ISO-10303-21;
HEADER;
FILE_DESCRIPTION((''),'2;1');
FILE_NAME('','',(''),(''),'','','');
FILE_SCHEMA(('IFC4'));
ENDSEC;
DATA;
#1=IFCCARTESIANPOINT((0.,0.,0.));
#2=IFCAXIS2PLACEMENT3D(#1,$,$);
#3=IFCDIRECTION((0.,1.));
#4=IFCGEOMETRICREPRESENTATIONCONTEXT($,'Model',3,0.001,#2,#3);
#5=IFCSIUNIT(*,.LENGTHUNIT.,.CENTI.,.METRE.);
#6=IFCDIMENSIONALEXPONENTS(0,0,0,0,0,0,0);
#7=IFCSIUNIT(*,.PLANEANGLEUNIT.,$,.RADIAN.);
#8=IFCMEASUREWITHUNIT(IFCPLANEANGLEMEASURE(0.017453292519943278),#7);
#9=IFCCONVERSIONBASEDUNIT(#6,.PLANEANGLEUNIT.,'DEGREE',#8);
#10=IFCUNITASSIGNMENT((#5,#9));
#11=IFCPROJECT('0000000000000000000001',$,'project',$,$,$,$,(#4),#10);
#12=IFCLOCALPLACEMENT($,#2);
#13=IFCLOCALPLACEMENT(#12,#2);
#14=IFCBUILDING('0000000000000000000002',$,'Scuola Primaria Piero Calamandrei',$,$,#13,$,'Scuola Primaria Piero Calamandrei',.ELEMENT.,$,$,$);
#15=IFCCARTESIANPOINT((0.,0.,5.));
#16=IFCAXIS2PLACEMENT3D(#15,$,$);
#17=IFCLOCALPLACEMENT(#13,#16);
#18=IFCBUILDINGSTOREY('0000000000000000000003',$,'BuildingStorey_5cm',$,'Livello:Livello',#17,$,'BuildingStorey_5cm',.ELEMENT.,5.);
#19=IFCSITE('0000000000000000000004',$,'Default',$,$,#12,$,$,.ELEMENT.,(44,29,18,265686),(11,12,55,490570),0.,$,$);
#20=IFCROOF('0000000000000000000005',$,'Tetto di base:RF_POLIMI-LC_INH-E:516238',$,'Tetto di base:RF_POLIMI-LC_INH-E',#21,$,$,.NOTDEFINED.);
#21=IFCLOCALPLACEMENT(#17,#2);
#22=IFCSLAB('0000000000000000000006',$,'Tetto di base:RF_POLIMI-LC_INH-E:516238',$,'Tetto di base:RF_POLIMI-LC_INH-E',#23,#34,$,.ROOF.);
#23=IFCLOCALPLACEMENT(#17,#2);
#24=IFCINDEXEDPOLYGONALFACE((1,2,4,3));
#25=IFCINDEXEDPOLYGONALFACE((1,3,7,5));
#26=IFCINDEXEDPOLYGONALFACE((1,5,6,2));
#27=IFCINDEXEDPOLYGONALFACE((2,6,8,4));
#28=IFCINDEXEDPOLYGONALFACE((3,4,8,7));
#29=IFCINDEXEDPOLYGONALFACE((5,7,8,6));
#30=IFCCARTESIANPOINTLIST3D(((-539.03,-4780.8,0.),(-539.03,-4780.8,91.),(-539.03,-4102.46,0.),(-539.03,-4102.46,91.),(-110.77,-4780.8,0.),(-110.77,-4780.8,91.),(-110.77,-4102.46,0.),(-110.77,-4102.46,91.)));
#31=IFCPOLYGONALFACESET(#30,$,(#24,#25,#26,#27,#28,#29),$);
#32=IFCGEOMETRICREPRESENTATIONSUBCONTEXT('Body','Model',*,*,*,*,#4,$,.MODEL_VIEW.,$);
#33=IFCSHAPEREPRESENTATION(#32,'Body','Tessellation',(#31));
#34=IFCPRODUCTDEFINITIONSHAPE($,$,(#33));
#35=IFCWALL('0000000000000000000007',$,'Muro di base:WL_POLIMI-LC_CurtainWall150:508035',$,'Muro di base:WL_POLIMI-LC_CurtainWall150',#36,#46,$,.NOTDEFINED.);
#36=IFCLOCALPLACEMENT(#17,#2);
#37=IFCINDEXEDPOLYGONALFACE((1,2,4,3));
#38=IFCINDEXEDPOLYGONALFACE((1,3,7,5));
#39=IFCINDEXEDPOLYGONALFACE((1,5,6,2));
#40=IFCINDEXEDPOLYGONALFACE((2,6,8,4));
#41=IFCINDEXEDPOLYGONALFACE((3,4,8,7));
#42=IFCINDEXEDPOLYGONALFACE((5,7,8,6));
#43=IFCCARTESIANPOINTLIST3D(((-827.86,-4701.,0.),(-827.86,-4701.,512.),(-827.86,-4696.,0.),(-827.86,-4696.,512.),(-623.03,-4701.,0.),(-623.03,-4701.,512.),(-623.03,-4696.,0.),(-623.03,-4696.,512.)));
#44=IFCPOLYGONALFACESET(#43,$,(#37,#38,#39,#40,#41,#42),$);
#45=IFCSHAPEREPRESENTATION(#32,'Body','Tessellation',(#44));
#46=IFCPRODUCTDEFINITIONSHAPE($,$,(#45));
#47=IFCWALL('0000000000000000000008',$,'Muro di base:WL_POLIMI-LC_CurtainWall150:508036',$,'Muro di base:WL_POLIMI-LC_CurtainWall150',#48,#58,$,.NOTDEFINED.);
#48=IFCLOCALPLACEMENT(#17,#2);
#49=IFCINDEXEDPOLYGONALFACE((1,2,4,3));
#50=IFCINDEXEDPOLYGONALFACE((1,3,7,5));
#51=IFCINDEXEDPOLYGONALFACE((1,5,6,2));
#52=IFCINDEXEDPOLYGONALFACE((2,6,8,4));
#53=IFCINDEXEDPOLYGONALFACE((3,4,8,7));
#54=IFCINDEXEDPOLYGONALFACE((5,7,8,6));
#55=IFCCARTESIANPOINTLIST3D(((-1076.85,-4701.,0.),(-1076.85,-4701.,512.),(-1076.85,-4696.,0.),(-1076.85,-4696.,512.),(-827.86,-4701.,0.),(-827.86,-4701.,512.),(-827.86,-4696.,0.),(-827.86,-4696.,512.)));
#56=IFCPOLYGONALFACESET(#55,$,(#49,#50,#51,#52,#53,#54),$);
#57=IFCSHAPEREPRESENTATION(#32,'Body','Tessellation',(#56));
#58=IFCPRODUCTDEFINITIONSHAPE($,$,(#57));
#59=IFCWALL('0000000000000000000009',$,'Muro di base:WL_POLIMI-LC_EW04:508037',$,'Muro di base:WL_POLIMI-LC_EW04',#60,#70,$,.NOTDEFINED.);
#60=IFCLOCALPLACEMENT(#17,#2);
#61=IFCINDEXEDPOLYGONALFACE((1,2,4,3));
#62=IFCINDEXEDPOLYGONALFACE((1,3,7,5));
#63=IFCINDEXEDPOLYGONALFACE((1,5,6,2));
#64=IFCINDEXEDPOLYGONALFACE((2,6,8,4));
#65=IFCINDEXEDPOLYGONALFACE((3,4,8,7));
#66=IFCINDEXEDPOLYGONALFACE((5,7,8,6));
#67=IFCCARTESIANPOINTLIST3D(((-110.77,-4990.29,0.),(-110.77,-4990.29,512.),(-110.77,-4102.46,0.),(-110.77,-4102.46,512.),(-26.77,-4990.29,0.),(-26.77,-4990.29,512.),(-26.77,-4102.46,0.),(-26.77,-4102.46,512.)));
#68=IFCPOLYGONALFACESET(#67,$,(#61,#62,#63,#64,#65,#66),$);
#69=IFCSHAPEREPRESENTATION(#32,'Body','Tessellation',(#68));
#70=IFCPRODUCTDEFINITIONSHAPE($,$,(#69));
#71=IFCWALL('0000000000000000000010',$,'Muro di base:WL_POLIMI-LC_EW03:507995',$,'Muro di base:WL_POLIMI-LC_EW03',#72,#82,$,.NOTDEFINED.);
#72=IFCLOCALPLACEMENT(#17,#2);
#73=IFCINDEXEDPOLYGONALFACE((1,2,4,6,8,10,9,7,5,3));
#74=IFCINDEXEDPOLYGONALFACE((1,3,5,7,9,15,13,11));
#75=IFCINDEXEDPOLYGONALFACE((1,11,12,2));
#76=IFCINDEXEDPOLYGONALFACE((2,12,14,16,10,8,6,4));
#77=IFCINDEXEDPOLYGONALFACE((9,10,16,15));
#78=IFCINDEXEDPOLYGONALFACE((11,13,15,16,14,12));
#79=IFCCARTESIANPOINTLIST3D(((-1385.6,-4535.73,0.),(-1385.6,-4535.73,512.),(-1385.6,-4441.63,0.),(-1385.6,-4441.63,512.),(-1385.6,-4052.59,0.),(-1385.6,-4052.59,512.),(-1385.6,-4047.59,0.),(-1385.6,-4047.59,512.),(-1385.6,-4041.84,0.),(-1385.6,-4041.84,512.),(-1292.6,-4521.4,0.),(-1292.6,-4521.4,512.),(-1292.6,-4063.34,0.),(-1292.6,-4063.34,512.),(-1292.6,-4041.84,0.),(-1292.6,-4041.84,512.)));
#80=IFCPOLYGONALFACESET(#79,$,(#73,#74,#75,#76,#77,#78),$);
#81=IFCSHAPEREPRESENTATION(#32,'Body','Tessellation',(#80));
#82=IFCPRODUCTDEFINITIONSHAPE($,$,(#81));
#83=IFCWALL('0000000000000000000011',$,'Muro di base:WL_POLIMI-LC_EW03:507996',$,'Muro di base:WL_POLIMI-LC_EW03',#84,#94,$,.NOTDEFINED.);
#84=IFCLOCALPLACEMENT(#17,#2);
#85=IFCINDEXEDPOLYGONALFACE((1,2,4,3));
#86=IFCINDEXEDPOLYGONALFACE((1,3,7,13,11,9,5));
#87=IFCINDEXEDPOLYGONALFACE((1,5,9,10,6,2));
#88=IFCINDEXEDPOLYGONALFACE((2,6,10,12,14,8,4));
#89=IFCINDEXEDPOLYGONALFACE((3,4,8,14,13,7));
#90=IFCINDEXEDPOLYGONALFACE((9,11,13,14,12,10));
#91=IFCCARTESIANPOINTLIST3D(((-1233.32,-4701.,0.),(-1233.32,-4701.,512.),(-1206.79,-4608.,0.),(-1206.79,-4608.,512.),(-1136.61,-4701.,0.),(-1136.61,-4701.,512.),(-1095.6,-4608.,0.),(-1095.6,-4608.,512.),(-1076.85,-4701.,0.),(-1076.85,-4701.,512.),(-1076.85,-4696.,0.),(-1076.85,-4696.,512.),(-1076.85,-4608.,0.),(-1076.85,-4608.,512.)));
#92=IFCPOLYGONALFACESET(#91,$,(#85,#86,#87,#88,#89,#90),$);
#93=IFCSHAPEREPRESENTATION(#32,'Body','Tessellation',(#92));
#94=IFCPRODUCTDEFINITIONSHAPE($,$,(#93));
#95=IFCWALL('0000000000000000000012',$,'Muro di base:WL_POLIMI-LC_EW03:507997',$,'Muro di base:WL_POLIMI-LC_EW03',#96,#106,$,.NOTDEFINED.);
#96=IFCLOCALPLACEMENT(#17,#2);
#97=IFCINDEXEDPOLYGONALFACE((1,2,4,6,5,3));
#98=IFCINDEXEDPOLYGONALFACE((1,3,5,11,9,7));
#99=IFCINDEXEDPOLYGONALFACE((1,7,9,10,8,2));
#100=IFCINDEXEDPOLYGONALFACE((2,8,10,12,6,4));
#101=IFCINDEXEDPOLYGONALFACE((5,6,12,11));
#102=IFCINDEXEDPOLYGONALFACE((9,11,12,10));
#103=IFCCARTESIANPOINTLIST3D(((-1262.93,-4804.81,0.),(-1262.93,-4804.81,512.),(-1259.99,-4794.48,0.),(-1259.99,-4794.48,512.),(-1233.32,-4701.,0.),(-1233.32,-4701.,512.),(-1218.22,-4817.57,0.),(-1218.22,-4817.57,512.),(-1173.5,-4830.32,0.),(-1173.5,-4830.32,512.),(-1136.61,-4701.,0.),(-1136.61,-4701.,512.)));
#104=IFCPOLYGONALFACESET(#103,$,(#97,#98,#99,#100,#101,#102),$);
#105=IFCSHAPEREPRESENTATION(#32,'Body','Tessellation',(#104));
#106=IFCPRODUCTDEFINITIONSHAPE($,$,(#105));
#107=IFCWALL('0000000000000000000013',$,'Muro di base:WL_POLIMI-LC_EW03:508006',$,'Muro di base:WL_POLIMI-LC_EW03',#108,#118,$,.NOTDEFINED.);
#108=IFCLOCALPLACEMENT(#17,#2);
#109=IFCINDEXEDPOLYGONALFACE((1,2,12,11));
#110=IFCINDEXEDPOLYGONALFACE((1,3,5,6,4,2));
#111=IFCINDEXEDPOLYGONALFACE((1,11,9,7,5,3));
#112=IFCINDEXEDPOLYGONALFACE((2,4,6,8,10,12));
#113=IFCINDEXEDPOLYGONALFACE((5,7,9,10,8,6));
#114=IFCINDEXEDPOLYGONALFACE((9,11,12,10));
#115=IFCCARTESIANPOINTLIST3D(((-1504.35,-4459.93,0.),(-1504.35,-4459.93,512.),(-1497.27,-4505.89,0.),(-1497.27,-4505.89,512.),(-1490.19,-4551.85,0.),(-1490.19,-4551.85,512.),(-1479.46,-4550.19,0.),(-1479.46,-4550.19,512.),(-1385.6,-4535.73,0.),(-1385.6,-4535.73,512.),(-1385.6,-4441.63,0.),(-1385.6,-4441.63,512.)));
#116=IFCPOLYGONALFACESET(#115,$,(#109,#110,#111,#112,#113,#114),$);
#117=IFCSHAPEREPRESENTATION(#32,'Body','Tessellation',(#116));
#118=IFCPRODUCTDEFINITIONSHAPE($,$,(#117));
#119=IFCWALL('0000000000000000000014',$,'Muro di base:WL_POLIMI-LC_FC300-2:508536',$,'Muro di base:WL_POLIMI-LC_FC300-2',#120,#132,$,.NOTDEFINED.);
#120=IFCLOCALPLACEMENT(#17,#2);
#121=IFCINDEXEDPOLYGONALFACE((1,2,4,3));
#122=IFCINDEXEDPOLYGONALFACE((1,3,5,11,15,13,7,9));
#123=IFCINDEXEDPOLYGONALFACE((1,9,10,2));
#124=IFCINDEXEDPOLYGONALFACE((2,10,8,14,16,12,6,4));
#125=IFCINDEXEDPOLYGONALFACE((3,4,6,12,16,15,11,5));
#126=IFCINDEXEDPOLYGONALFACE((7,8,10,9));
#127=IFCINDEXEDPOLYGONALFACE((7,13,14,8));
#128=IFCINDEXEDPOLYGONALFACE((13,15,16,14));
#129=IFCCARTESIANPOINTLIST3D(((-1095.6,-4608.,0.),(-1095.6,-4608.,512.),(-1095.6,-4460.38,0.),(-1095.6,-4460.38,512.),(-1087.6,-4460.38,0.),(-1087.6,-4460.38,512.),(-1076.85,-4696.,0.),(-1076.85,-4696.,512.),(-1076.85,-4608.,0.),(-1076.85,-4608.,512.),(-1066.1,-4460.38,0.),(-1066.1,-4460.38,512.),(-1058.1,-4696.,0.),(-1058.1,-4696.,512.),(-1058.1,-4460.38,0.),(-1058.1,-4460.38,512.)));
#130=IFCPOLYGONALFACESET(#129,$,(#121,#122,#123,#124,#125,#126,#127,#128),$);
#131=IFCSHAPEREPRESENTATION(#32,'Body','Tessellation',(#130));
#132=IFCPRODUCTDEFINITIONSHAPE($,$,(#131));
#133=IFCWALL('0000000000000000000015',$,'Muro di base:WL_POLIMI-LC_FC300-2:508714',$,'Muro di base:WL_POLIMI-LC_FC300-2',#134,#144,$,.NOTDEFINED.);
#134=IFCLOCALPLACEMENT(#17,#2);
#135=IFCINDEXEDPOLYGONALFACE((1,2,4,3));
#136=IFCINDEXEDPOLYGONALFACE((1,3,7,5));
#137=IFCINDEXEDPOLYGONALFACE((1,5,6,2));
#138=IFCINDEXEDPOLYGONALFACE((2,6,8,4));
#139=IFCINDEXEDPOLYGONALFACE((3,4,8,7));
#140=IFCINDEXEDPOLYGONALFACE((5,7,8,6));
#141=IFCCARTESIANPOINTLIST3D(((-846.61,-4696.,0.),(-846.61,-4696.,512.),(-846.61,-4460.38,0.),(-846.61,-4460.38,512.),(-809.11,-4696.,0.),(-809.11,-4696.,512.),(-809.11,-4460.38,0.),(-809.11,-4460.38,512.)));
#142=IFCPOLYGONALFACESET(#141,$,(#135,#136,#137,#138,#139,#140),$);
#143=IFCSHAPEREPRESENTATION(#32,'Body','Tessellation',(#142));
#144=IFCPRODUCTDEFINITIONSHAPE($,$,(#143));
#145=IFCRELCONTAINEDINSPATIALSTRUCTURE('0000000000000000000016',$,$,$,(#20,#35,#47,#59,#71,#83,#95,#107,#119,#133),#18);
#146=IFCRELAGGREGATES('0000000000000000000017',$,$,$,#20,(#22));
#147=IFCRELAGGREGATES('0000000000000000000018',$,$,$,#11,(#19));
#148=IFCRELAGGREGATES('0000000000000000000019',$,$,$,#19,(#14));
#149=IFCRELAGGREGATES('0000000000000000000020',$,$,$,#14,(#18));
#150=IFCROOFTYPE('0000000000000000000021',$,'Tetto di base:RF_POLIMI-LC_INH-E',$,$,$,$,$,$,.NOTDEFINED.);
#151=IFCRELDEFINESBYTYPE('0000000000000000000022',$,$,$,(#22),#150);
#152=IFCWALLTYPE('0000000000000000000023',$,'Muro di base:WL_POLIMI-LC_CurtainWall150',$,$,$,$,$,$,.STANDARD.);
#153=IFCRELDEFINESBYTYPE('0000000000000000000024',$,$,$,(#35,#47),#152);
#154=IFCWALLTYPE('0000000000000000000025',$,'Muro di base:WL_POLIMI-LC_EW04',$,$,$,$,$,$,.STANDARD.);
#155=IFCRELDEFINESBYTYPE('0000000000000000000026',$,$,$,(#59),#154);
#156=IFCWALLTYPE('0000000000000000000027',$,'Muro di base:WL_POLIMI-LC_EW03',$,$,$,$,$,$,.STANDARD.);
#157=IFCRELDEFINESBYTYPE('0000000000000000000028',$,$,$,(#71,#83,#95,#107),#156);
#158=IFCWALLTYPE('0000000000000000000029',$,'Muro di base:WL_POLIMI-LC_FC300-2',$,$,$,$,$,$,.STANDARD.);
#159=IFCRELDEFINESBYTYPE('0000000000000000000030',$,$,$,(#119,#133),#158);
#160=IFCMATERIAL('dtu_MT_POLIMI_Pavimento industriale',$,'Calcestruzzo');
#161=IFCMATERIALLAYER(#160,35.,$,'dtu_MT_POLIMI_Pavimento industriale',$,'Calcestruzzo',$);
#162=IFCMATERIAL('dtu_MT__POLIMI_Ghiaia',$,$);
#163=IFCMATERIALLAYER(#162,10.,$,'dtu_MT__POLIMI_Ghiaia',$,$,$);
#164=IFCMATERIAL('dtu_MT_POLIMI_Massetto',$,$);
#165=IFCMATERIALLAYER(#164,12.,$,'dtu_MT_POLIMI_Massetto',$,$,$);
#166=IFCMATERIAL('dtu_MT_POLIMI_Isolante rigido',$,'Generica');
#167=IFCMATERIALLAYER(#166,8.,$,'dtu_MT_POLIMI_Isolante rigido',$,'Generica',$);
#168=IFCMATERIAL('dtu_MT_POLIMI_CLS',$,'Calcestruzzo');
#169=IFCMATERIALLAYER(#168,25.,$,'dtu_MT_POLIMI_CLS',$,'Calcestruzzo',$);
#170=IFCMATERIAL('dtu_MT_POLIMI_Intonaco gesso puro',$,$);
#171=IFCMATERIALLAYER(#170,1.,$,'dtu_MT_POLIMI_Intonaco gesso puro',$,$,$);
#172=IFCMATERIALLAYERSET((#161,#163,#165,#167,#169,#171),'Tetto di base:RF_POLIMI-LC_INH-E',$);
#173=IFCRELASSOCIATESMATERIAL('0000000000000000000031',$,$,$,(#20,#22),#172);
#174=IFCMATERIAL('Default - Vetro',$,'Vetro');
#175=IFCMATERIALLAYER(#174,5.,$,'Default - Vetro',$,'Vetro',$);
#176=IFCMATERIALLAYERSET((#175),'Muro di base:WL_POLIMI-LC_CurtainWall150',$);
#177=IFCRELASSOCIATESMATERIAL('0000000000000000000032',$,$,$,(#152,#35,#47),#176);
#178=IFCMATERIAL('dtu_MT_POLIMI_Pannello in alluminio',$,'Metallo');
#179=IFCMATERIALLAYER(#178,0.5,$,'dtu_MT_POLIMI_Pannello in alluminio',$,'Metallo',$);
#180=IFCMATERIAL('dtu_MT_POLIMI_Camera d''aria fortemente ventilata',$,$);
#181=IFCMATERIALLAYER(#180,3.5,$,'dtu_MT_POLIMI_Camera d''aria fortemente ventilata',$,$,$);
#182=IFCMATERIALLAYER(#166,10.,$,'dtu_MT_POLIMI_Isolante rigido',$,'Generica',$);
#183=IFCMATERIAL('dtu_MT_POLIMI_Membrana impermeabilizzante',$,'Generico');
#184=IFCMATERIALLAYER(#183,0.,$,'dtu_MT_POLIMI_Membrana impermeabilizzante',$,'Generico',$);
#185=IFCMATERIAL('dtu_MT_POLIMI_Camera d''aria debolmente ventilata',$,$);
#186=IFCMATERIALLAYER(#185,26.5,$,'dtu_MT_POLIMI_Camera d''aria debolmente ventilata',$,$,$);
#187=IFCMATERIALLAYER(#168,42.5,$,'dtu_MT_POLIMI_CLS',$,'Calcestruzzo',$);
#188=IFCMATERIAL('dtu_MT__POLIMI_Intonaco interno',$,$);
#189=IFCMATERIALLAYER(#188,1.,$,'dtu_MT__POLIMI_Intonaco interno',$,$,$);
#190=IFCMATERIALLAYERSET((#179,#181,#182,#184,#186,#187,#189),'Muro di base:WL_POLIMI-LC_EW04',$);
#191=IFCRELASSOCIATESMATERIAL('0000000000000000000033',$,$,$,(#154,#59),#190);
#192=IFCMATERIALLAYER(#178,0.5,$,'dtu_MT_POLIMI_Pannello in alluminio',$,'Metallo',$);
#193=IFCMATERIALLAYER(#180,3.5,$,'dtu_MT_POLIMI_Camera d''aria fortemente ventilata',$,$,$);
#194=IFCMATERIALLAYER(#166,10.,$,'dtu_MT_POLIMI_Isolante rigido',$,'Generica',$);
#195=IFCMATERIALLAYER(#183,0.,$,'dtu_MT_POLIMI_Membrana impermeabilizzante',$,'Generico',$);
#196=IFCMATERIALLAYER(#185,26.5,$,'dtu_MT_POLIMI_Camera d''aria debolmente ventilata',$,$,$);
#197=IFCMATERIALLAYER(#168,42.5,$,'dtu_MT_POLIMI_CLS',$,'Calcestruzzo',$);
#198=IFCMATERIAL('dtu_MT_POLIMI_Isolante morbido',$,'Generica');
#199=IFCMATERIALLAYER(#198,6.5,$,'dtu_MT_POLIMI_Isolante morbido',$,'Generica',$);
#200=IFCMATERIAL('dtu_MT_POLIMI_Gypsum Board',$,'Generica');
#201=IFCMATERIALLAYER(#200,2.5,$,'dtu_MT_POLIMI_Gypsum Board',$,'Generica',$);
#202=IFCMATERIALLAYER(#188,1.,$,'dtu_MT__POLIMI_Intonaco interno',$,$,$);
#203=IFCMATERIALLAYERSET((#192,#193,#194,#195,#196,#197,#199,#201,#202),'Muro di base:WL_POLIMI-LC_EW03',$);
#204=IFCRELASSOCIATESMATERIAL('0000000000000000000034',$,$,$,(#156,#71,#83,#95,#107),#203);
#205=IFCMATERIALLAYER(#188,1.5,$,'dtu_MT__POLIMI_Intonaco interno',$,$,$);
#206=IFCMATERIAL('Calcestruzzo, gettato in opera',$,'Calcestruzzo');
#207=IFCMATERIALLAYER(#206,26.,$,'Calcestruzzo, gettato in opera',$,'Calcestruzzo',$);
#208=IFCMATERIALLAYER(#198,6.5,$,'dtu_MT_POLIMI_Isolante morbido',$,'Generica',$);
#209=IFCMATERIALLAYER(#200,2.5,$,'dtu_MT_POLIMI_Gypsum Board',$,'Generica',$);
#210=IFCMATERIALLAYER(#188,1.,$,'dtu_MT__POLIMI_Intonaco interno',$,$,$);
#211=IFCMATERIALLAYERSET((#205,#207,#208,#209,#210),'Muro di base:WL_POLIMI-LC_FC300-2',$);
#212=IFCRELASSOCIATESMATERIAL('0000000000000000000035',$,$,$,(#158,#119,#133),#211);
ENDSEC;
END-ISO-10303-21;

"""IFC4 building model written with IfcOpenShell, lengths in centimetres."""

from ifc_helpers import new_model, entity, si_unit, converted_unit, direction, frame, frame_2d, origin, place, context, subcontext, project, spatial, polyline, rectangle, outline, extrude, material, layer, layer_set, layer_usage, type_object, element, aggregate, save


model = new_model("IFC4")

# Units and contexts
model_context = context("Model", 3, precision=0.001, world=origin(), true_north=direction((0.0, 1.0)))
body_context = subcontext(model_context, "Body", "Model", "MODEL_VIEW")
ifc_project = project(units=[si_unit("LENGTHUNIT", "METRE", prefix="CENTI"), converted_unit("PLANEANGLEUNIT", "DEGREE", entity("IfcPlaneAngleMeasure", 0.017453292519943278), si_unit("PLANEANGLEUNIT", "RADIAN"), dimensions=[0, 0, 0, 0, 0, 0, 0])], contexts=[model_context])

# Site, building, storey
site_placement = place(None, origin())
site = spatial("IfcSite", under=ifc_project, at=site_placement, Name="Default", CompositionType="ELEMENT", RefLatitude=(44, 29, 18, 265686), RefLongitude=(11, 12, 55, 490570), RefElevation=0.0)
building_placement = place(site_placement, origin())
building = spatial("IfcBuilding", under=site, at=building_placement, Name="Scuola Primaria Piero Calamandrei", LongName="Scuola Primaria Piero Calamandrei", CompositionType="ELEMENT")
storey_placement = place(building_placement, frame((0.0, 0.0, 5.0)))
storey = spatial("IfcBuildingStorey", under=building, at=storey_placement, Name="BuildingStorey_5cm", ObjectType="Livello:Livello", LongName="BuildingStorey_5cm", CompositionType="ELEMENT", Elevation=5.0)

# Roof, slab
ifc_material_1 = material(Name="dtu_MT_POLIMI_Pavimento industriale", Category="Calcestruzzo")
ifc_layer_1 = layer(ifc_material_1, 35.0, Name="dtu_MT_POLIMI_Pavimento industriale", Category="Calcestruzzo")
ifc_material_2 = material(Name="dtu_MT__POLIMI_Ghiaia")
ifc_layer_2 = layer(ifc_material_2, 10.0, Name="dtu_MT__POLIMI_Ghiaia")
ifc_material_3 = material(Name="dtu_MT_POLIMI_Massetto")
ifc_layer_3 = layer(ifc_material_3, 12.0, Name="dtu_MT_POLIMI_Massetto")
ifc_material_4 = material(Name="dtu_MT_POLIMI_Isolante rigido", Category="Generica")
ifc_layer_4 = layer(ifc_material_4, 8.0, Name="dtu_MT_POLIMI_Isolante rigido", Category="Generica")
ifc_material_5 = material(Name="dtu_MT_POLIMI_CLS", Category="Calcestruzzo")
ifc_layer_5 = layer(ifc_material_5, 25.0, Name="dtu_MT_POLIMI_CLS", Category="Calcestruzzo")
ifc_material_6 = material(Name="dtu_MT_POLIMI_Intonaco gesso puro")
ifc_layer_6 = layer(ifc_material_6, 1.0, Name="dtu_MT_POLIMI_Intonaco gesso puro")
ifc_layer_set_1 = layer_set([ifc_layer_1, ifc_layer_2, ifc_layer_3, ifc_layer_4, ifc_layer_5, ifc_layer_6], Name="Tetto di base:RF_POLIMI-LC_INH-E")
roof_type = type_object("IfcRoofType", Name="Tetto di base:RF_POLIMI-LC_INH-E", PredefinedType="NOTDEFINED")
roof_1_placement = place(storey_placement, frame((-539.03, -4780.8, 0.0)))
roof_1 = element("IfcRoof", 1, at=roof_1_placement, inside=storey, material=ifc_layer_set_1, Name="Tetto di base:RF_POLIMI-LC_INH-E:516238", ObjectType="Tetto di base:RF_POLIMI-LC_INH-E", PredefinedType="NOTDEFINED")
slab_1_placement = place(roof_1_placement, origin())
slab_1 = element("IfcSlab", 2, at=slab_1_placement, type_object=roof_type, material=ifc_layer_set_1, Name="Tetto di base:RF_POLIMI-LC_INH-E:516238", ObjectType="Tetto di base:RF_POLIMI-LC_INH-E", PredefinedType="ROOF", context=body_context, shape_type="SweptSolid", body=[
    extrude(rectangle(XDim=678.34, YDim=428.26, at=frame_2d((0.0, 0.0), x_axis=(0.0, -1.0))), frame((214.13, 339.17, 0.0)), (0.0, 0.0, 1.0), 91.0),
])
aggregate(roof_1, [slab_1])

# Walls
ifc_material_7 = material(Name="Default - Vetro", Category="Vetro")
ifc_layer_7 = layer(ifc_material_7, 5.0, Name="Default - Vetro", Category="Vetro")
ifc_layer_set_2 = layer_set([ifc_layer_7], Name="Muro di base:WL_POLIMI-LC_CurtainWall150")
ifc_layer_usage_1 = layer_usage(ifc_layer_set_2, "AXIS2", "NEGATIVE", 2.5)
wall_type_1 = type_object("IfcWallType", Name="Muro di base:WL_POLIMI-LC_CurtainWall150", PredefinedType="STANDARD", material=ifc_layer_set_2)
wall_1_placement = place(storey_placement, frame((-623.03, -4698.5, 0.0), z_axis=(0.0, 0.0, 1.0), x_axis=(-1.0, 0.0, 0.0)))
element("IfcWall", 3, at=wall_1_placement, inside=storey, type_object=wall_type_1, material=ifc_layer_usage_1, Name="Muro di base:WL_POLIMI-LC_CurtainWall150:508035", ObjectType="Muro di base:WL_POLIMI-LC_CurtainWall150", PredefinedType="NOTDEFINED", context=body_context, shape_type="SweptSolid", body=[
    extrude(rectangle(XDim=204.83, YDim=5.0, at=frame_2d((102.41, 0.0), x_axis=(-1.0, 0.0))), origin(), (0.0, 0.0, 1.0), 512.0),
])
ifc_layer_usage_2 = layer_usage(ifc_layer_set_2, "AXIS2", "NEGATIVE", 2.5)
wall_2_placement = place(storey_placement, frame((-827.86, -4698.5, 0.0), z_axis=(0.0, 0.0, 1.0), x_axis=(-1.0, 0.0, 0.0)))
element("IfcWall", 4, at=wall_2_placement, inside=storey, type_object=wall_type_1, material=ifc_layer_usage_2, Name="Muro di base:WL_POLIMI-LC_CurtainWall150:508036", ObjectType="Muro di base:WL_POLIMI-LC_CurtainWall150", PredefinedType="NOTDEFINED", context=body_context, shape_type="SweptSolid", body=[
    extrude(rectangle(XDim=248.99, YDim=5.0, at=frame_2d((124.5, 0.0), x_axis=(-1.0, 0.0))), origin(), (0.0, 0.0, 1.0), 512.0),
])
ifc_material_8 = material(Name="dtu_MT_POLIMI_Pannello in alluminio", Category="Metallo")
ifc_layer_8 = layer(ifc_material_8, 0.5, Name="dtu_MT_POLIMI_Pannello in alluminio", Category="Metallo")
ifc_material_9 = material(Name="dtu_MT_POLIMI_Camera d'aria fortemente ventilata")
ifc_layer_9 = layer(ifc_material_9, 3.5, Name="dtu_MT_POLIMI_Camera d'aria fortemente ventilata")
ifc_layer_10 = layer(ifc_material_4, 10.0, Name="dtu_MT_POLIMI_Isolante rigido", Category="Generica")
ifc_material_10 = material(Name="dtu_MT_POLIMI_Membrana impermeabilizzante", Category="Generico")
ifc_layer_11 = layer(ifc_material_10, 0.0, Name="dtu_MT_POLIMI_Membrana impermeabilizzante", Category="Generico")
ifc_material_11 = material(Name="dtu_MT_POLIMI_Camera d'aria debolmente ventilata")
ifc_layer_12 = layer(ifc_material_11, 26.5, Name="dtu_MT_POLIMI_Camera d'aria debolmente ventilata")
ifc_layer_13 = layer(ifc_material_5, 42.5, Name="dtu_MT_POLIMI_CLS", Category="Calcestruzzo")
ifc_material_12 = material(Name="dtu_MT__POLIMI_Intonaco interno")
ifc_layer_14 = layer(ifc_material_12, 1.0, Name="dtu_MT__POLIMI_Intonaco interno")
ifc_layer_set_3 = layer_set([ifc_layer_8, ifc_layer_9, ifc_layer_10, ifc_layer_11, ifc_layer_12, ifc_layer_13, ifc_layer_14], Name="Muro di base:WL_POLIMI-LC_EW04")
ifc_layer_usage_3 = layer_usage(ifc_layer_set_3, "AXIS2", "NEGATIVE", 42.0)
wall_type_2 = type_object("IfcWallType", Name="Muro di base:WL_POLIMI-LC_EW04", PredefinedType="STANDARD", material=ifc_layer_set_3)
wall_3_placement = place(storey_placement, frame((-68.77, -4990.29, 0.0), z_axis=(0.0, 0.0, 1.0), x_axis=(0.0, 1.0, 0.0)))
element("IfcWall", 5, at=wall_3_placement, inside=storey, type_object=wall_type_2, material=ifc_layer_usage_3, Name="Muro di base:WL_POLIMI-LC_EW04:508037", ObjectType="Muro di base:WL_POLIMI-LC_EW04", PredefinedType="NOTDEFINED", context=body_context, shape_type="SweptSolid", body=[
    extrude(rectangle(XDim=887.82, YDim=84.0, at=frame_2d((443.91, 0.0), x_axis=(-1.0, 0.0))), origin(), (0.0, 0.0, 1.0), 512.0),
])
ifc_layer_15 = layer(ifc_material_8, 0.5, Name="dtu_MT_POLIMI_Pannello in alluminio", Category="Metallo")
ifc_layer_16 = layer(ifc_material_9, 3.5, Name="dtu_MT_POLIMI_Camera d'aria fortemente ventilata")
ifc_layer_17 = layer(ifc_material_4, 10.0, Name="dtu_MT_POLIMI_Isolante rigido", Category="Generica")
ifc_layer_18 = layer(ifc_material_10, 0.0, Name="dtu_MT_POLIMI_Membrana impermeabilizzante", Category="Generico")
ifc_layer_19 = layer(ifc_material_11, 26.5, Name="dtu_MT_POLIMI_Camera d'aria debolmente ventilata")
ifc_layer_20 = layer(ifc_material_5, 42.5, Name="dtu_MT_POLIMI_CLS", Category="Calcestruzzo")
ifc_material_13 = material(Name="dtu_MT_POLIMI_Isolante morbido", Category="Generica")
ifc_layer_21 = layer(ifc_material_13, 6.5, Name="dtu_MT_POLIMI_Isolante morbido", Category="Generica")
ifc_material_14 = material(Name="dtu_MT_POLIMI_Gypsum Board", Category="Generica")
ifc_layer_22 = layer(ifc_material_14, 2.5, Name="dtu_MT_POLIMI_Gypsum Board", Category="Generica")
ifc_layer_23 = layer(ifc_material_12, 1.0, Name="dtu_MT__POLIMI_Intonaco interno")
ifc_layer_set_4 = layer_set([ifc_layer_15, ifc_layer_16, ifc_layer_17, ifc_layer_18, ifc_layer_19, ifc_layer_20, ifc_layer_21, ifc_layer_22, ifc_layer_23], Name="Muro di base:WL_POLIMI-LC_EW03")
ifc_layer_usage_4 = layer_usage(ifc_layer_set_4, "AXIS2", "NEGATIVE", 46.5)
wall_type_3 = type_object("IfcWallType", Name="Muro di base:WL_POLIMI-LC_EW03", PredefinedType="STANDARD", material=ifc_layer_set_4)
wall_4_placement = place(storey_placement, frame((-1339.1, -4535.73, 0.0), z_axis=(0.0, 0.0, 1.0), x_axis=(0.0, 1.0, 0.0)))
element("IfcWall", 6, at=wall_4_placement, inside=storey, type_object=wall_type_3, material=ifc_layer_usage_4, Name="Muro di base:WL_POLIMI-LC_EW03:507995", ObjectType="Muro di base:WL_POLIMI-LC_EW03", PredefinedType="NOTDEFINED", context=body_context, shape_type="SweptSolid", body=[
    extrude(outline(polyline([(493.89, -46.5), (493.89, 46.5), (488.14, 46.5), (483.14, 46.5), (94.1, 46.5), (0.0, 46.5), (14.33, -46.5), (472.39, -46.5), (493.89, -46.5)])), origin(), (0.0, 0.0, 1.0), 512.0),
])
ifc_layer_usage_5 = layer_usage(ifc_layer_set_4, "AXIS2", "NEGATIVE", 46.5)
wall_5_placement = place(storey_placement, frame((-1076.85, -4654.5, 0.0), z_axis=(0.0, 0.0, 1.0), x_axis=(-1.0, 0.0, 0.0)))
element("IfcWall", 7, at=wall_5_placement, inside=storey, type_object=wall_type_3, material=ifc_layer_usage_5, Name="Muro di base:WL_POLIMI-LC_EW03:507996", ObjectType="Muro di base:WL_POLIMI-LC_EW03", PredefinedType="NOTDEFINED", context=body_context, shape_type="SweptSolid", body=[
    extrude(outline(polyline([(129.94, -46.5), (156.47, 46.5), (59.76, 46.5), (0.0, 46.5), (0.0, 41.5), (0.0, -46.5), (18.75, -46.5), (129.94, -46.5)])), origin(), (0.0, 0.0, 1.0), 512.0),
])
ifc_layer_usage_6 = layer_usage(ifc_layer_set_4, "AXIS2", "NEGATIVE", 46.5)
wall_6_placement = place(storey_placement, frame((-1181.33, -4688.24, 0.0), z_axis=(0.0, 0.0, 1.0), x_axis=(-0.274316, -0.96164, 0.0)))
element("IfcWall", 8, at=wall_6_placement, inside=storey, type_object=wall_type_3, material=ifc_layer_usage_6, Name="Muro di base:WL_POLIMI-LC_EW03:507997", ObjectType="Muro di base:WL_POLIMI-LC_EW03", PredefinedType="NOTDEFINED", context=body_context, shape_type="SweptSolid", body=[
    extrude(outline(polyline([(134.48, -46.5), (134.48, 0.0), (134.48, 46.5), (0.0, 46.5), (26.53, -46.5), (123.74, -46.5), (134.48, -46.5)])), origin(), (0.0, 0.0, 1.0), 512.0),
])
ifc_layer_usage_7 = layer_usage(ifc_layer_set_4, "AXIS2", "NEGATIVE", 46.5)
wall_7_placement = place(storey_placement, frame((-1497.27, -4505.89, 0.0), z_axis=(0.0, 0.0, 1.0), x_axis=(0.988335, 0.152294, 0.0)))
element("IfcWall", 9, at=wall_7_placement, inside=storey, type_object=wall_type_3, material=ifc_layer_usage_7, Name="Muro di base:WL_POLIMI-LC_EW03:508006", ObjectType="Muro di base:WL_POLIMI-LC_EW03", PredefinedType="NOTDEFINED", context=body_context, shape_type="SweptSolid", body=[
    extrude(outline(polyline([(105.82, -46.5), (120.15, 46.5), (0.0, 46.5), (0.0, 0.0), (0.0, -46.5), (10.85, -46.5), (105.82, -46.5)])), origin(), (0.0, 0.0, 1.0), 512.0),
])
ifc_layer_24 = layer(ifc_material_12, 1.5, Name="dtu_MT__POLIMI_Intonaco interno")
ifc_material_15 = material(Name="Calcestruzzo, gettato in opera", Category="Calcestruzzo")
ifc_layer_25 = layer(ifc_material_15, 26.0, Name="Calcestruzzo, gettato in opera", Category="Calcestruzzo")
ifc_layer_26 = layer(ifc_material_13, 6.5, Name="dtu_MT_POLIMI_Isolante morbido", Category="Generica")
ifc_layer_27 = layer(ifc_material_14, 2.5, Name="dtu_MT_POLIMI_Gypsum Board", Category="Generica")
ifc_layer_28 = layer(ifc_material_12, 1.0, Name="dtu_MT__POLIMI_Intonaco interno")
ifc_layer_set_5 = layer_set([ifc_layer_24, ifc_layer_25, ifc_layer_26, ifc_layer_27, ifc_layer_28], Name="Muro di base:WL_POLIMI-LC_FC300-2")
ifc_layer_usage_8 = layer_usage(ifc_layer_set_5, "AXIS2", "NEGATIVE", 18.75)
wall_type_4 = type_object("IfcWallType", Name="Muro di base:WL_POLIMI-LC_FC300-2", PredefinedType="STANDARD", material=ifc_layer_set_5)
wall_8_placement = place(storey_placement, frame((-1076.85, -4460.38, 0.0), z_axis=(0.0, 0.0, 1.0), x_axis=(0.0, -1.0, 0.0)))
element("IfcWall", 10, at=wall_8_placement, inside=storey, type_object=wall_type_4, material=ifc_layer_usage_8, Name="Muro di base:WL_POLIMI-LC_FC300-2:508536", ObjectType="Muro di base:WL_POLIMI-LC_FC300-2", PredefinedType="NOTDEFINED", context=body_context, shape_type="SweptSolid", body=[
    extrude(outline(polyline([(-18.75, 51.81), (-18.75, -95.81), (-10.75, -95.81), (10.75, -95.81), (18.75, -95.81), (18.75, 139.81), (0.0, 139.81), (0.0, 51.81), (-18.75, 51.81)])), frame((95.81, 0.0, 0.0), z_axis=(0.0, 0.0, -1.0), x_axis=(0.0, 1.0, 0.0)), (0.0, 0.0, -1.0), 512.0),
])
ifc_layer_usage_9 = layer_usage(ifc_layer_set_5, "AXIS2", "NEGATIVE", 18.75)
wall_9_placement = place(storey_placement, frame((-827.86, -4696.0, 0.0), z_axis=(0.0, 0.0, 1.0), x_axis=(0.0, 1.0, 0.0)))
element("IfcWall", 11, at=wall_9_placement, inside=storey, type_object=wall_type_4, material=ifc_layer_usage_9, Name="Muro di base:WL_POLIMI-LC_FC300-2:508714", ObjectType="Muro di base:WL_POLIMI-LC_FC300-2", PredefinedType="NOTDEFINED", context=body_context, shape_type="SweptSolid", body=[
    extrude(rectangle(XDim=235.61, YDim=37.5, at=frame_2d((117.81, 0.0), x_axis=(-1.0, 0.0))), origin(), (0.0, 0.0, 1.0), 512.0),
])

save(model, "model.ifc")
